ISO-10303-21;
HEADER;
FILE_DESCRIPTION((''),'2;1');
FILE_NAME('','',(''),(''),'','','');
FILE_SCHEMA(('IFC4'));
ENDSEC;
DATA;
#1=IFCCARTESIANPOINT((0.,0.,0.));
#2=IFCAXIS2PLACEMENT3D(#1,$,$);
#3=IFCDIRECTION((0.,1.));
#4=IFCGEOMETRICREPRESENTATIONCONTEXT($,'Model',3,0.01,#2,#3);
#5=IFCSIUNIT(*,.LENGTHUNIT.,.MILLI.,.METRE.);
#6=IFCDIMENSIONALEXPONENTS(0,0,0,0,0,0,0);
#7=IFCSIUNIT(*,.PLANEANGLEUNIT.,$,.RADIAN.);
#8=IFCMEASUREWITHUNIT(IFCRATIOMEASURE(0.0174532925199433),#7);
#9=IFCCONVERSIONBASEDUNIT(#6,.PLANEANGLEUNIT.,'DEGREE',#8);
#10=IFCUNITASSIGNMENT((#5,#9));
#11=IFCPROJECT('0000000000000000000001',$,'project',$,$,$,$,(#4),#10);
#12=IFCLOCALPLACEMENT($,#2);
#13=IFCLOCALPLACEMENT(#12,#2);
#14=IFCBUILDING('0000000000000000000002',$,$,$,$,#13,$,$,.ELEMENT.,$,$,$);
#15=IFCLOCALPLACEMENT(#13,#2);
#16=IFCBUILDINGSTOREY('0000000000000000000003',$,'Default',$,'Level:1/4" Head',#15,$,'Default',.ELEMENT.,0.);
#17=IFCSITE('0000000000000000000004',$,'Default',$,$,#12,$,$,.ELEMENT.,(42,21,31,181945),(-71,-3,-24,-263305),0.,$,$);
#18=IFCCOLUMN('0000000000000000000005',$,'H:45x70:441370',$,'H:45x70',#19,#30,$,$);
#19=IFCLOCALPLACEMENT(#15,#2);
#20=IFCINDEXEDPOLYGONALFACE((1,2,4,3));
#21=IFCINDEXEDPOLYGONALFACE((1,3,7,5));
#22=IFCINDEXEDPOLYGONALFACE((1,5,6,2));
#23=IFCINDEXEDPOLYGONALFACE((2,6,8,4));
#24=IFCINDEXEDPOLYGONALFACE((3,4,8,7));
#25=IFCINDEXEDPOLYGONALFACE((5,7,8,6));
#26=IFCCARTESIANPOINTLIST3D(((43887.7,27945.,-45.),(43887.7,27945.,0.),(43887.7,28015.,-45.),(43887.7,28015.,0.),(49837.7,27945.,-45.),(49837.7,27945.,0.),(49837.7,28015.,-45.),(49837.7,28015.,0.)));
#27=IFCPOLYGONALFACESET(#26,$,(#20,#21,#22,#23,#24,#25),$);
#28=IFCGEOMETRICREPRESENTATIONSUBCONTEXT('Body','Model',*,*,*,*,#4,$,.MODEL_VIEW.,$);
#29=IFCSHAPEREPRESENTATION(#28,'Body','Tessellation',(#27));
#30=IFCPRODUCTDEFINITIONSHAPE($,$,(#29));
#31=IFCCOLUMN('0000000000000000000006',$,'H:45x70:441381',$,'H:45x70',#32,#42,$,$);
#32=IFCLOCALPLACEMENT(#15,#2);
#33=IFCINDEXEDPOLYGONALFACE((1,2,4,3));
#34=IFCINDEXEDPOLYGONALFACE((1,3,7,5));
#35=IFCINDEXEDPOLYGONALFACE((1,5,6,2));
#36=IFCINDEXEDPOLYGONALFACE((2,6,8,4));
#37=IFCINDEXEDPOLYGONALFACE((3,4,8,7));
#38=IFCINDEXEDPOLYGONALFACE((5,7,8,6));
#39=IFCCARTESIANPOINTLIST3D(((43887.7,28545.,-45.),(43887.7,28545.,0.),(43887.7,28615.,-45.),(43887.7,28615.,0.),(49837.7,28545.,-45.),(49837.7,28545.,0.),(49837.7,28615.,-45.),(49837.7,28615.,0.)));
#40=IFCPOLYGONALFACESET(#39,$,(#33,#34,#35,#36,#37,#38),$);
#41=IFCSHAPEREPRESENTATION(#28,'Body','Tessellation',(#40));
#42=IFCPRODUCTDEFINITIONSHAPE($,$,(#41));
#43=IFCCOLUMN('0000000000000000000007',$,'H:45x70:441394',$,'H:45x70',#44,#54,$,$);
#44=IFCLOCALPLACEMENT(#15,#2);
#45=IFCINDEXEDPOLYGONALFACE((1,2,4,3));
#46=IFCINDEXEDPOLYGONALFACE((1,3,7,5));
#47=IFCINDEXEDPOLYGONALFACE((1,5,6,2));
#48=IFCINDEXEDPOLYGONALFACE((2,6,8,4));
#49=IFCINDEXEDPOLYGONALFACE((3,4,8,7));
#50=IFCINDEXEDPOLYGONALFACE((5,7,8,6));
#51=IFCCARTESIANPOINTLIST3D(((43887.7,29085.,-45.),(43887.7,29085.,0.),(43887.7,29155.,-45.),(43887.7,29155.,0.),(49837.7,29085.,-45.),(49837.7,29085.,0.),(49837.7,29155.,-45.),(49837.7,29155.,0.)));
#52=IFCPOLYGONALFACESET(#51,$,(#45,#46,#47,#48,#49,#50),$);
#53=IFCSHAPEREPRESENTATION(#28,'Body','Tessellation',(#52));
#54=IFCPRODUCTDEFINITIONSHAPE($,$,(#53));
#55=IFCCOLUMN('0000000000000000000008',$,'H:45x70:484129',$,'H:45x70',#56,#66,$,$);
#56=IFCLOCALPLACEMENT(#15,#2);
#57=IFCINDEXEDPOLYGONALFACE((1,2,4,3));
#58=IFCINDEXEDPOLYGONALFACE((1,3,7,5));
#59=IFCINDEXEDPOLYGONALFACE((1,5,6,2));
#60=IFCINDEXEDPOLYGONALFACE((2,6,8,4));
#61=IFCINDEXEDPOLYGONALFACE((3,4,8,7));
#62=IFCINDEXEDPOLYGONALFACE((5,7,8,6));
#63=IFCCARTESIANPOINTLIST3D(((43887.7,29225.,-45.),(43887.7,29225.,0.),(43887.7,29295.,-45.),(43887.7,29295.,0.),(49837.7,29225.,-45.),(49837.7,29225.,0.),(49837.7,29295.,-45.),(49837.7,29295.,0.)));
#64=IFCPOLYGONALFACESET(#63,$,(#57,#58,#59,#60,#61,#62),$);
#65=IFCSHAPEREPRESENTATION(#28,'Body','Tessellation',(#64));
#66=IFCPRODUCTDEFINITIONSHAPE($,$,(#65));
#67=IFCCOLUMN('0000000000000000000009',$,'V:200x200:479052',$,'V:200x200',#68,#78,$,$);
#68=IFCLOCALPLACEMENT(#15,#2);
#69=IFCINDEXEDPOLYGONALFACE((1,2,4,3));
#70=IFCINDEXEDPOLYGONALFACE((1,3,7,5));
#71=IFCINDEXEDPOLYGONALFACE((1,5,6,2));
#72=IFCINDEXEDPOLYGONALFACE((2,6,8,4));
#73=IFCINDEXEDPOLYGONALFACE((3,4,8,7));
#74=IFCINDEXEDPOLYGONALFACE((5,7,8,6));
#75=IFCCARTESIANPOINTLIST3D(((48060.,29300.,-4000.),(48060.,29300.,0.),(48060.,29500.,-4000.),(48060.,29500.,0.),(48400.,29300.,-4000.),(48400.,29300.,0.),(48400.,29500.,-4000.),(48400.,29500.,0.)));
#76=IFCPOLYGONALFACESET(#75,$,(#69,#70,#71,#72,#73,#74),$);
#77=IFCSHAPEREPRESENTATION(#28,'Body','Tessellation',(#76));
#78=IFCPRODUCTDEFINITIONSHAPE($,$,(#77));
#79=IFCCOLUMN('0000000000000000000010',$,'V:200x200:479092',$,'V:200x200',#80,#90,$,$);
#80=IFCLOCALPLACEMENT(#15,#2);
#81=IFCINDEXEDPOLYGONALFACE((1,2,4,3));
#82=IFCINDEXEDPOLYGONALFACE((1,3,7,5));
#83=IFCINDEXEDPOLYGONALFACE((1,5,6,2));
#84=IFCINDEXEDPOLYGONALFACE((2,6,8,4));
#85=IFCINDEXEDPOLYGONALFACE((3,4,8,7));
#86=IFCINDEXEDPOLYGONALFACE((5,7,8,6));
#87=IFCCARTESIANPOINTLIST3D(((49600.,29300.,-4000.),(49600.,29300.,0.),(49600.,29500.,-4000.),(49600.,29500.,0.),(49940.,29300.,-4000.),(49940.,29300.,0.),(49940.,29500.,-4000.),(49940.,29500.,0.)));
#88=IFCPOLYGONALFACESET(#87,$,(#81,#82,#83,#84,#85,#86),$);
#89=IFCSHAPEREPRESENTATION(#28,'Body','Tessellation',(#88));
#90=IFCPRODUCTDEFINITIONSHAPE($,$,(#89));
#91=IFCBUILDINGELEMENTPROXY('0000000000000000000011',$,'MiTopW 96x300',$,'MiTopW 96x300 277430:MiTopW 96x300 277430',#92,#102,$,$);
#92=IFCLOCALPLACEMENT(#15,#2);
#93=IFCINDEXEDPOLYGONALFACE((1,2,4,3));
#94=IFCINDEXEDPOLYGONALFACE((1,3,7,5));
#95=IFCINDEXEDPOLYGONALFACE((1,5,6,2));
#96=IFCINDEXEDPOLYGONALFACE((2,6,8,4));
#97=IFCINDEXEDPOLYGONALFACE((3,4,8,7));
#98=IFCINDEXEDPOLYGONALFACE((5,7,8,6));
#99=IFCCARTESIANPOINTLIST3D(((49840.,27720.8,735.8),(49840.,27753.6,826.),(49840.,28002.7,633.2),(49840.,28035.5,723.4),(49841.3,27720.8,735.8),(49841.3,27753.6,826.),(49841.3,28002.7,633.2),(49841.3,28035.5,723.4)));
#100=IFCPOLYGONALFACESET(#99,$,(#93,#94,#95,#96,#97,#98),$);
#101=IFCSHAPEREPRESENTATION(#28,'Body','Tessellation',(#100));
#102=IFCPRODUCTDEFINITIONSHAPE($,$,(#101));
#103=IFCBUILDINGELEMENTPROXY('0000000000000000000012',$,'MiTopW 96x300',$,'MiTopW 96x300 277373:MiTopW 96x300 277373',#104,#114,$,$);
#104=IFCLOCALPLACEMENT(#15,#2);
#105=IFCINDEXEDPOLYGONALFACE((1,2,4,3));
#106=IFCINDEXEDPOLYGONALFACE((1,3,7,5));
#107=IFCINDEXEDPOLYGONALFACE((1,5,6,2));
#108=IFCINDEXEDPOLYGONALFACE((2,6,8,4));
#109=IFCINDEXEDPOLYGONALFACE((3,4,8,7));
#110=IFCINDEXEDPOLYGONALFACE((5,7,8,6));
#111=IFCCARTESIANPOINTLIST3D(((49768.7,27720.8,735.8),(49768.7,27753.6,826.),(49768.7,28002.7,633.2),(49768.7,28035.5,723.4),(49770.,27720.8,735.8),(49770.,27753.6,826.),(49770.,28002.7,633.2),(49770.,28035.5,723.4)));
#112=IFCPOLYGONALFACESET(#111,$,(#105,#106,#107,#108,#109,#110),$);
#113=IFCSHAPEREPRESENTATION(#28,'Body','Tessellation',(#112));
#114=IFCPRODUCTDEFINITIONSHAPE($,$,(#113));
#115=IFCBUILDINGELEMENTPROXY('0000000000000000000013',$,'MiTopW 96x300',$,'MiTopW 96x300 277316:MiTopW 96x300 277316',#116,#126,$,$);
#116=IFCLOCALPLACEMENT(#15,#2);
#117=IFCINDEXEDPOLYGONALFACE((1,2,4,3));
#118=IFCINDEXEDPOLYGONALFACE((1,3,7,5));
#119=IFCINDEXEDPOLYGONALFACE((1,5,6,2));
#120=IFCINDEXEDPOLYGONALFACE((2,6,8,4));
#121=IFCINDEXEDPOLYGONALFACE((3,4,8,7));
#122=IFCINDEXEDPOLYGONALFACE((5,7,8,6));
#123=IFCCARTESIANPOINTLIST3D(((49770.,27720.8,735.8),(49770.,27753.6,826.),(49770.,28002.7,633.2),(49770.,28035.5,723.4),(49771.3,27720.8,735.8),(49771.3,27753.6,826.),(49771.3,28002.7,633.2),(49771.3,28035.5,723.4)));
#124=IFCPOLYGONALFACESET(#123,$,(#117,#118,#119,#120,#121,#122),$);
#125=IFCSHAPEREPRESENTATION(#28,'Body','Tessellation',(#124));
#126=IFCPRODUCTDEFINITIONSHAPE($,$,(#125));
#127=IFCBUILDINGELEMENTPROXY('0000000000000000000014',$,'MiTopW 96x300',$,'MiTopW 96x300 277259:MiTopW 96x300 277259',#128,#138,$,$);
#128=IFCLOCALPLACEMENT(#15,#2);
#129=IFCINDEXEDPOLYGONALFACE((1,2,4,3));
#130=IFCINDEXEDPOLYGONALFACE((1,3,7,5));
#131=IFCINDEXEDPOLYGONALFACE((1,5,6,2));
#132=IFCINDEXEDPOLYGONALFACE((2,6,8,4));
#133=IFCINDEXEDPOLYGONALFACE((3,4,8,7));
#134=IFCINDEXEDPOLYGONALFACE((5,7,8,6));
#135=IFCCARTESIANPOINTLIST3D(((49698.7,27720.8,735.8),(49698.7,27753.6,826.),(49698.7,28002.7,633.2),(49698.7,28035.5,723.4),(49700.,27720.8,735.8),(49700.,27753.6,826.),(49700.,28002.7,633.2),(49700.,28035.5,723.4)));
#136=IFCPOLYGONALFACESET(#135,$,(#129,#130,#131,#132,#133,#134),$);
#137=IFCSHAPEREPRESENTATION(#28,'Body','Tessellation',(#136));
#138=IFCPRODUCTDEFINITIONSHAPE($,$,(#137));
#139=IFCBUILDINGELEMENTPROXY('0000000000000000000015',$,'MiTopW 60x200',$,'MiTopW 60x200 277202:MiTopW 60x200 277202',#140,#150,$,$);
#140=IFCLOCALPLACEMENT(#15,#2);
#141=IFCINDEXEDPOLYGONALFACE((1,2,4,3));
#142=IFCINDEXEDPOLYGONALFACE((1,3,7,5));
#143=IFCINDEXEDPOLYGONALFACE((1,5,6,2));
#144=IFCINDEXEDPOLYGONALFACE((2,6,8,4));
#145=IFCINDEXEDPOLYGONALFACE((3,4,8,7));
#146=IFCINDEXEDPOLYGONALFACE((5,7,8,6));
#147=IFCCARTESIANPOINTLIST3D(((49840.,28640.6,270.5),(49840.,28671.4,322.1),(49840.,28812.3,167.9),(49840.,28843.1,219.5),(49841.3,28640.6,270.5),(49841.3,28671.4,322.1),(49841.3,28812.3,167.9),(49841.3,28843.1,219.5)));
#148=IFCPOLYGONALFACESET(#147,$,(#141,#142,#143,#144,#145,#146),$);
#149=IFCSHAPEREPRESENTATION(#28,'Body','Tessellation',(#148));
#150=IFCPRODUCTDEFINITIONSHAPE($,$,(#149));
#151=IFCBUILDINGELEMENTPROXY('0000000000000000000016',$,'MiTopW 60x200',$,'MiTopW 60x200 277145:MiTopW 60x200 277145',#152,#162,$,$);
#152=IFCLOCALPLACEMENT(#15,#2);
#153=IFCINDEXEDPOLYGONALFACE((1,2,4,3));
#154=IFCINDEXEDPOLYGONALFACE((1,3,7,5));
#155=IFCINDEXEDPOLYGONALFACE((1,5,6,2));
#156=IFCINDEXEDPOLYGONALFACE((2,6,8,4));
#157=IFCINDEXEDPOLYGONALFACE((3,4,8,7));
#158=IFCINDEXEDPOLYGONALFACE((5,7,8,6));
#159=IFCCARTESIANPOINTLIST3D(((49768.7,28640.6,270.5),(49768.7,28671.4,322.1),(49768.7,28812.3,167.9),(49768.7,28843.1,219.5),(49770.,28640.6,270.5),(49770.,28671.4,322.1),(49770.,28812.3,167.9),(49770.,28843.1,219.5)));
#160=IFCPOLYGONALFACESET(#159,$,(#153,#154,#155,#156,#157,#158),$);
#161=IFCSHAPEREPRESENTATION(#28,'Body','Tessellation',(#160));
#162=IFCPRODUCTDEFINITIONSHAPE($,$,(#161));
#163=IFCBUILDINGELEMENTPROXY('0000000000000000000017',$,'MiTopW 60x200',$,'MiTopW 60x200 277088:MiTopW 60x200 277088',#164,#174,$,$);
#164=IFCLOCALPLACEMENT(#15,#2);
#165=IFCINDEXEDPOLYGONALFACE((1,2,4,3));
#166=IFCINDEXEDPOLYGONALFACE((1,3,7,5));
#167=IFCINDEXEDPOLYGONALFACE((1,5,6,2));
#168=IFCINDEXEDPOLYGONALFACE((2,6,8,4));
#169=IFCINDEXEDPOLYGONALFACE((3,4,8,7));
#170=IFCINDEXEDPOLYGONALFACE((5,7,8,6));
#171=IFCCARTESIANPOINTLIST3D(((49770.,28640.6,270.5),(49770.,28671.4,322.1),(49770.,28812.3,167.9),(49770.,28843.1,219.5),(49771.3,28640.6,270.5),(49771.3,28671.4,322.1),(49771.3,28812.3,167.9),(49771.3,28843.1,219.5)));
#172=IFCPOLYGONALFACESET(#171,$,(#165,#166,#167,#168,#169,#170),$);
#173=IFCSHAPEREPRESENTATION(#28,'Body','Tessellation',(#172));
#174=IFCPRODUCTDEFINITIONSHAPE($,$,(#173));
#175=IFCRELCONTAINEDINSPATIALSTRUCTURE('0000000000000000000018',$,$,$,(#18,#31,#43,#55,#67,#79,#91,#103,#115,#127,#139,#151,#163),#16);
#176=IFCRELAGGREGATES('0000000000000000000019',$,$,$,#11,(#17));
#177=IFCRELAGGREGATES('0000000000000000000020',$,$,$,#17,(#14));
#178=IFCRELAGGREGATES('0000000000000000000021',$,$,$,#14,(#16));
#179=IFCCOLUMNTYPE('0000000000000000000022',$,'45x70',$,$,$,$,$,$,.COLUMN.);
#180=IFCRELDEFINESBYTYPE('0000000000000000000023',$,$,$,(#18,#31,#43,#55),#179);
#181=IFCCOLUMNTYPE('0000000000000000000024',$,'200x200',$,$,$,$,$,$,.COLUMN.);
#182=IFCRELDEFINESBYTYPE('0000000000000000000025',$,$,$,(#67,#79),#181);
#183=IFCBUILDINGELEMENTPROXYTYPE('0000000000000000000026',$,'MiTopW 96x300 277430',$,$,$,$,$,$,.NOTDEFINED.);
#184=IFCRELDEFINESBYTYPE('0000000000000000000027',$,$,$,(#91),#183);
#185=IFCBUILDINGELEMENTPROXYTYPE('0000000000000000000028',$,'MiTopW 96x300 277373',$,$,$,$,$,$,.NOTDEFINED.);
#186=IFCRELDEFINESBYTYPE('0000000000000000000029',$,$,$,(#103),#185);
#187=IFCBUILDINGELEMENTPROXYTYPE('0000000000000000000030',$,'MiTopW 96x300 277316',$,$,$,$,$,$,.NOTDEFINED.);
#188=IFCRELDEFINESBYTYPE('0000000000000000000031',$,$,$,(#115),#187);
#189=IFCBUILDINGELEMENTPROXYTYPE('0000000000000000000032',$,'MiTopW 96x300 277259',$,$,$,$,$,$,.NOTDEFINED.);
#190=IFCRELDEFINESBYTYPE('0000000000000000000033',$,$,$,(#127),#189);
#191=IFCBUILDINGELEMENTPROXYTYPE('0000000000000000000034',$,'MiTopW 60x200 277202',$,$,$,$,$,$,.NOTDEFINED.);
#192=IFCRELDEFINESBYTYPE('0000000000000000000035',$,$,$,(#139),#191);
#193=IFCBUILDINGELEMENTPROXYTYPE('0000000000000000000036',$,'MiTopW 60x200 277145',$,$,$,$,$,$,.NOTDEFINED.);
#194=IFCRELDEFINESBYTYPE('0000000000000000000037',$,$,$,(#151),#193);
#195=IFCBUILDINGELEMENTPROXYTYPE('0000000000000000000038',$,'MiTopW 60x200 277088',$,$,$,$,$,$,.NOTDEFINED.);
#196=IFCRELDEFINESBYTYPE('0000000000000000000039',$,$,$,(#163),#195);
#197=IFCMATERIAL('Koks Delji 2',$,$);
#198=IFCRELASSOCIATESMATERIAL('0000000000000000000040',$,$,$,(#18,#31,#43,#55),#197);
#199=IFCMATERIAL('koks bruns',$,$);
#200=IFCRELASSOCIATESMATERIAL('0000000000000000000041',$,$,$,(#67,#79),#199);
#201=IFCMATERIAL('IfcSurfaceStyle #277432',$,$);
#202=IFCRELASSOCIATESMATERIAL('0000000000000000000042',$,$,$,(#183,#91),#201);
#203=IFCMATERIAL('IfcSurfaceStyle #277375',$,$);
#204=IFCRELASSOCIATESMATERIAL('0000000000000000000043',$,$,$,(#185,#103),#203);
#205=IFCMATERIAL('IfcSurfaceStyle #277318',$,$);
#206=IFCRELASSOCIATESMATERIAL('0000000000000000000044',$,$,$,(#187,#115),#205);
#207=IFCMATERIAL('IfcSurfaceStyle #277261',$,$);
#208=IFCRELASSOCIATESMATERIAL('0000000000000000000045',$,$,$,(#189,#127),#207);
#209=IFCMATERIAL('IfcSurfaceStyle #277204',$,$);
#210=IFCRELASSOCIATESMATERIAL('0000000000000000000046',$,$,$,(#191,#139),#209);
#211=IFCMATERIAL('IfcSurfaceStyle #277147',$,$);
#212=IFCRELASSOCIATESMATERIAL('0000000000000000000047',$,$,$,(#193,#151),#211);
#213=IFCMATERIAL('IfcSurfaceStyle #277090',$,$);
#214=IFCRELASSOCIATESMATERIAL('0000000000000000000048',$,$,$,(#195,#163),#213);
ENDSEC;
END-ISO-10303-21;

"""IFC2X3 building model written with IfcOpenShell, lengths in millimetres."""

from ifc_helpers import new_model, entity, si_unit, converted_unit, direction, frame, frame_2d, origin, origin_2d_with_axis, place, context, subcontext, project, spatial, polyline, rectangle, outline, extrude, source, transform, mapped, material, type_object, type_shapes, element, save


model = new_model("IFC2X3")

# Units and contexts
model_context = context("Model", 3, precision=0.01, world=origin(), true_north=direction((0.0, 1.0)))
body_context = subcontext(model_context, "Body", "Model", "MODEL_VIEW")
ifc_project = project(units=[si_unit("LENGTHUNIT", "METRE", prefix="MILLI"), converted_unit("PLANEANGLEUNIT", "DEGREE", entity("IfcRatioMeasure", 0.0174532925199433), si_unit("PLANEANGLEUNIT", "RADIAN"), dimensions=[0, 0, 0, 0, 0, 0, 0])], contexts=[model_context])

# Site, building, storey
site_placement = place(None, origin())
site = spatial("IfcSite", under=ifc_project, at=site_placement, Name="Default", CompositionType="ELEMENT", RefLatitude=(42, 21, 31, 181945), RefLongitude=(-71, -3, -24, -263305), RefElevation=0.0)
building_placement = place(site_placement, origin())
building = spatial("IfcBuilding", under=site, at=building_placement, CompositionType="ELEMENT")
storey_placement = place(building_placement, origin())
storey = spatial("IfcBuildingStorey", under=building, at=storey_placement, Name="Default", ObjectType="Level:1/4\" Head", LongName="Default", CompositionType="ELEMENT", Elevation=0.0)

# Columns
ifc_material_1 = material(Name="Koks Delji 2")
column_type_1 = type_object("IfcColumnType", Name="45x70", PredefinedType="COLUMN")
shared_shape_1 = source(origin(), body_context, "Body", "SweptSolid", [
    extrude(rectangle(XDim=70.0, YDim=5950.0, at=frame_2d((0.0, 0.0), x_axis=(1.0, 0.0))), frame((2975.0, 237.8, 0.0), z_axis=(0.0, 0.0, 1.0), x_axis=(0.0, -1.0, 0.0)), (0.0, 0.0, 1.0), 45.0),
])
type_shapes(column_type_1, [shared_shape_1])
for number, where, z_axis, x_axis, name in (
    (1, (49837.7, 28217.8, -45.0), (0.0, 0.0, 1.0), (-1.0, 0.0, 0.0), "H:45x70:441370"),
    (2, (49837.7, 28817.8, -45.0), (0.0, 0.0, 1.0), (-1.0, 0.0, 0.0), "H:45x70:441381"),
    (3, (49837.7, 29357.8, -45.0), (0.0, 0.0, 1.0), (-1.0, 0.0, 0.0), "H:45x70:441394"),
    (4, (49837.7, 29497.8, -45.0), (0.0, 0.0, 1.0), (-1.0, 0.0, 0.0), "H:45x70:484129"),
):
    element("IfcColumn", number, at=place(storey_placement, frame(where, z_axis=z_axis, x_axis=x_axis)), inside=storey, type_object=column_type_1, material=ifc_material_1, Name=name, ObjectType="H:45x70", context=body_context, shape_type="MappedRepresentation", body=[
        mapped(shared_shape_1, transform((0.0, 0.0, 0.0), scale=1.0)),
    ])
ifc_material_2 = material(Name="koks bruns")
column_type_2 = type_object("IfcColumnType", Name="200x200", PredefinedType="COLUMN")
shared_shape_2 = source(origin(), body_context, "Body", "SweptSolid", [
    extrude(rectangle(XDim=340.0, YDim=200.0, at=origin_2d_with_axis()), frame((100.0, 280.0, -4000.0), z_axis=(0.0, 0.0, 1.0), x_axis=(0.0, -1.0, 0.0)), (0.0, 0.0, 1.0), 4000.0),
])
type_shapes(column_type_2, [shared_shape_2])
for number, where, z_axis, x_axis, name in (
    (5, (48510.0, 29300.0, 0.0), (0.0, 0.0, 1.0), (0.0, 1.0, 0.0), "V:200x200:479052"),
    (6, (50050.0, 29300.0, 0.0), (0.0, 0.0, 1.0), (0.0, 1.0, 0.0), "V:200x200:479092"),
):
    element("IfcColumn", number, at=place(storey_placement, frame(where, z_axis=z_axis, x_axis=x_axis)), inside=storey, type_object=column_type_2, material=ifc_material_2, Name=name, ObjectType="V:200x200", context=body_context, shape_type="MappedRepresentation", body=[
        mapped(shared_shape_2, transform((0.0, 0.0, 0.0), scale=1.0)),
    ])

# Building element proxies
ifc_material_3 = material(Name="IfcSurfaceStyle #277432")
building_element_proxy_type_1 = type_object("IfcBuildingElementProxyType", Name="MiTopW 96x300 277430", PredefinedType="NOTDEFINED", material=ifc_material_3)
shared_shape_3 = source(origin(), body_context, "Body", "SweptSolid", [
    extrude(outline(polyline([(-150.0, -48.0), (150.0, -48.0), (150.0, 48.0), (-150.0, 48.0), (-150.0, -48.0)])), frame((150.0, 48.0, 0.0), z_axis=(0.0, 0.0, 1.0), x_axis=(-1.0, 0.0, 0.0)), (0.0, 0.0, 1.0), 1.3),
])
type_shapes(building_element_proxy_type_1, [shared_shape_3])
proxy_1_placement = place(building_placement, frame((49841.3, 28002.7, 633.2), z_axis=(-1.0, 0.0, 0.0), x_axis=(0.0, -0.939693, 0.34202)))
element("IfcBuildingElementProxy", 7, at=proxy_1_placement, inside=storey, type_object=building_element_proxy_type_1, material=ifc_material_3, Name="MiTopW 96x300", ObjectType="MiTopW 96x300 277430:MiTopW 96x300 277430", context=body_context, shape_type="MappedRepresentation", body=[
    mapped(shared_shape_3, transform((0.0, 0.0, 0.0), scale=1.0)),
])
ifc_material_4 = material(Name="IfcSurfaceStyle #277375")
building_element_proxy_type_2 = type_object("IfcBuildingElementProxyType", Name="MiTopW 96x300 277373", PredefinedType="NOTDEFINED", material=ifc_material_4)
shared_shape_4 = source(origin(), body_context, "Body", "SweptSolid", [
    extrude(outline(polyline([(-150.0, -48.0), (150.0, -48.0), (150.0, 48.0), (-150.0, 48.0), (-150.0, -48.0)])), frame((150.0, 48.0, 0.0), z_axis=(0.0, 0.0, 1.0), x_axis=(-1.0, 0.0, 0.0)), (0.0, 0.0, 1.0), 1.3),
])
type_shapes(building_element_proxy_type_2, [shared_shape_4])
proxy_2_placement = place(building_placement, frame((49770.0, 28002.7, 633.2), z_axis=(-1.0, 0.0, 0.0), x_axis=(0.0, -0.939693, 0.34202)))
element("IfcBuildingElementProxy", 8, at=proxy_2_placement, inside=storey, type_object=building_element_proxy_type_2, material=ifc_material_4, Name="MiTopW 96x300", ObjectType="MiTopW 96x300 277373:MiTopW 96x300 277373", context=body_context, shape_type="MappedRepresentation", body=[
    mapped(shared_shape_4, transform((0.0, 0.0, 0.0), scale=1.0)),
])
ifc_material_5 = material(Name="IfcSurfaceStyle #277318")
building_element_proxy_type_3 = type_object("IfcBuildingElementProxyType", Name="MiTopW 96x300 277316", PredefinedType="NOTDEFINED", material=ifc_material_5)
shared_shape_5 = source(origin(), body_context, "Body", "SweptSolid", [
    extrude(outline(polyline([(-150.0, -48.0), (150.0, -48.0), (150.0, 48.0), (-150.0, 48.0), (-150.0, -48.0)])), frame((150.0, 48.0, 0.0), z_axis=(0.0, 0.0, 1.0), x_axis=(-1.0, 0.0, 0.0)), (0.0, 0.0, 1.0), 1.3),
])
type_shapes(building_element_proxy_type_3, [shared_shape_5])
proxy_3_placement = place(building_placement, frame((49771.3, 28002.7, 633.2), z_axis=(-1.0, 0.0, 0.0), x_axis=(0.0, -0.939693, 0.34202)))
element("IfcBuildingElementProxy", 9, at=proxy_3_placement, inside=storey, type_object=building_element_proxy_type_3, material=ifc_material_5, Name="MiTopW 96x300", ObjectType="MiTopW 96x300 277316:MiTopW 96x300 277316", context=body_context, shape_type="MappedRepresentation", body=[
    mapped(shared_shape_5, transform((0.0, 0.0, 0.0), scale=1.0)),
])
ifc_material_6 = material(Name="IfcSurfaceStyle #277261")
building_element_proxy_type_4 = type_object("IfcBuildingElementProxyType", Name="MiTopW 96x300 277259", PredefinedType="NOTDEFINED", material=ifc_material_6)
shared_shape_6 = source(origin(), body_context, "Body", "SweptSolid", [
    extrude(outline(polyline([(-150.0, -48.0), (150.0, -48.0), (150.0, 48.0), (-150.0, 48.0), (-150.0, -48.0)])), frame((150.0, 48.0, 0.0), z_axis=(0.0, 0.0, 1.0), x_axis=(-1.0, 0.0, 0.0)), (0.0, 0.0, 1.0), 1.3),
])
type_shapes(building_element_proxy_type_4, [shared_shape_6])
proxy_4_placement = place(building_placement, frame((49700.0, 28002.7, 633.2), z_axis=(-1.0, 0.0, 0.0), x_axis=(0.0, -0.939693, 0.34202)))
element("IfcBuildingElementProxy", 10, at=proxy_4_placement, inside=storey, type_object=building_element_proxy_type_4, material=ifc_material_6, Name="MiTopW 96x300", ObjectType="MiTopW 96x300 277259:MiTopW 96x300 277259", context=body_context, shape_type="MappedRepresentation", body=[
    mapped(shared_shape_6, transform((0.0, 0.0, 0.0), scale=1.0)),
])
ifc_material_7 = material(Name="IfcSurfaceStyle #277204")
building_element_proxy_type_5 = type_object("IfcBuildingElementProxyType", Name="MiTopW 60x200 277202", PredefinedType="NOTDEFINED", material=ifc_material_7)
shared_shape_7 = source(origin(), body_context, "Body", "SweptSolid", [
    extrude(outline(polyline([(-100.0, -30.0), (100.0, -30.0), (100.0, 30.0), (-100.0, 30.0), (-100.0, -30.0)])), frame((100.0, 30.0, 0.0), z_axis=(0.0, 0.0, 1.0), x_axis=(-1.0, 0.0, 0.0)), (0.0, 0.0, 1.0), 1.3),
])
type_shapes(building_element_proxy_type_5, [shared_shape_7])
proxy_5_placement = place(building_placement, frame((49841.3, 28812.3, 167.9), z_axis=(-1.0, 0.0, 0.0), x_axis=(0.0, -0.858392, 0.512994)))
element("IfcBuildingElementProxy", 11, at=proxy_5_placement, inside=storey, type_object=building_element_proxy_type_5, material=ifc_material_7, Name="MiTopW 60x200", ObjectType="MiTopW 60x200 277202:MiTopW 60x200 277202", context=body_context, shape_type="MappedRepresentation", body=[
    mapped(shared_shape_7, transform((0.0, 0.0, 0.0), scale=1.0)),
])
ifc_material_8 = material(Name="IfcSurfaceStyle #277147")
building_element_proxy_type_6 = type_object("IfcBuildingElementProxyType", Name="MiTopW 60x200 277145", PredefinedType="NOTDEFINED", material=ifc_material_8)
shared_shape_8 = source(origin(), body_context, "Body", "SweptSolid", [
    extrude(outline(polyline([(-100.0, -30.0), (100.0, -30.0), (100.0, 30.0), (-100.0, 30.0), (-100.0, -30.0)])), frame((100.0, 30.0, 0.0), z_axis=(0.0, 0.0, 1.0), x_axis=(-1.0, 0.0, 0.0)), (0.0, 0.0, 1.0), 1.3),
])
type_shapes(building_element_proxy_type_6, [shared_shape_8])
proxy_6_placement = place(building_placement, frame((49770.0, 28812.3, 167.9), z_axis=(-1.0, 0.0, 0.0), x_axis=(0.0, -0.858392, 0.512994)))
element("IfcBuildingElementProxy", 12, at=proxy_6_placement, inside=storey, type_object=building_element_proxy_type_6, material=ifc_material_8, Name="MiTopW 60x200", ObjectType="MiTopW 60x200 277145:MiTopW 60x200 277145", context=body_context, shape_type="MappedRepresentation", body=[
    mapped(shared_shape_8, transform((0.0, 0.0, 0.0), scale=1.0)),
])
ifc_material_9 = material(Name="IfcSurfaceStyle #277090")
building_element_proxy_type_7 = type_object("IfcBuildingElementProxyType", Name="MiTopW 60x200 277088", PredefinedType="NOTDEFINED", material=ifc_material_9)
shared_shape_9 = source(origin(), body_context, "Body", "SweptSolid", [
    extrude(outline(polyline([(-100.0, -30.0), (100.0, -30.0), (100.0, 30.0), (-100.0, 30.0), (-100.0, -30.0)])), frame((100.0, 30.0, 0.0), z_axis=(0.0, 0.0, 1.0), x_axis=(-1.0, 0.0, 0.0)), (0.0, 0.0, 1.0), 1.3),
])
type_shapes(building_element_proxy_type_7, [shared_shape_9])
proxy_7_placement = place(building_placement, frame((49771.3, 28812.3, 167.9), z_axis=(-1.0, 0.0, 0.0), x_axis=(0.0, -0.858392, 0.512994)))
element("IfcBuildingElementProxy", 13, at=proxy_7_placement, inside=storey, type_object=building_element_proxy_type_7, material=ifc_material_9, Name="MiTopW 60x200", ObjectType="MiTopW 60x200 277088:MiTopW 60x200 277088", context=body_context, shape_type="MappedRepresentation", body=[
    mapped(shared_shape_9, transform((0.0, 0.0, 0.0), scale=1.0)),
])

save(model, "model.ifc")
